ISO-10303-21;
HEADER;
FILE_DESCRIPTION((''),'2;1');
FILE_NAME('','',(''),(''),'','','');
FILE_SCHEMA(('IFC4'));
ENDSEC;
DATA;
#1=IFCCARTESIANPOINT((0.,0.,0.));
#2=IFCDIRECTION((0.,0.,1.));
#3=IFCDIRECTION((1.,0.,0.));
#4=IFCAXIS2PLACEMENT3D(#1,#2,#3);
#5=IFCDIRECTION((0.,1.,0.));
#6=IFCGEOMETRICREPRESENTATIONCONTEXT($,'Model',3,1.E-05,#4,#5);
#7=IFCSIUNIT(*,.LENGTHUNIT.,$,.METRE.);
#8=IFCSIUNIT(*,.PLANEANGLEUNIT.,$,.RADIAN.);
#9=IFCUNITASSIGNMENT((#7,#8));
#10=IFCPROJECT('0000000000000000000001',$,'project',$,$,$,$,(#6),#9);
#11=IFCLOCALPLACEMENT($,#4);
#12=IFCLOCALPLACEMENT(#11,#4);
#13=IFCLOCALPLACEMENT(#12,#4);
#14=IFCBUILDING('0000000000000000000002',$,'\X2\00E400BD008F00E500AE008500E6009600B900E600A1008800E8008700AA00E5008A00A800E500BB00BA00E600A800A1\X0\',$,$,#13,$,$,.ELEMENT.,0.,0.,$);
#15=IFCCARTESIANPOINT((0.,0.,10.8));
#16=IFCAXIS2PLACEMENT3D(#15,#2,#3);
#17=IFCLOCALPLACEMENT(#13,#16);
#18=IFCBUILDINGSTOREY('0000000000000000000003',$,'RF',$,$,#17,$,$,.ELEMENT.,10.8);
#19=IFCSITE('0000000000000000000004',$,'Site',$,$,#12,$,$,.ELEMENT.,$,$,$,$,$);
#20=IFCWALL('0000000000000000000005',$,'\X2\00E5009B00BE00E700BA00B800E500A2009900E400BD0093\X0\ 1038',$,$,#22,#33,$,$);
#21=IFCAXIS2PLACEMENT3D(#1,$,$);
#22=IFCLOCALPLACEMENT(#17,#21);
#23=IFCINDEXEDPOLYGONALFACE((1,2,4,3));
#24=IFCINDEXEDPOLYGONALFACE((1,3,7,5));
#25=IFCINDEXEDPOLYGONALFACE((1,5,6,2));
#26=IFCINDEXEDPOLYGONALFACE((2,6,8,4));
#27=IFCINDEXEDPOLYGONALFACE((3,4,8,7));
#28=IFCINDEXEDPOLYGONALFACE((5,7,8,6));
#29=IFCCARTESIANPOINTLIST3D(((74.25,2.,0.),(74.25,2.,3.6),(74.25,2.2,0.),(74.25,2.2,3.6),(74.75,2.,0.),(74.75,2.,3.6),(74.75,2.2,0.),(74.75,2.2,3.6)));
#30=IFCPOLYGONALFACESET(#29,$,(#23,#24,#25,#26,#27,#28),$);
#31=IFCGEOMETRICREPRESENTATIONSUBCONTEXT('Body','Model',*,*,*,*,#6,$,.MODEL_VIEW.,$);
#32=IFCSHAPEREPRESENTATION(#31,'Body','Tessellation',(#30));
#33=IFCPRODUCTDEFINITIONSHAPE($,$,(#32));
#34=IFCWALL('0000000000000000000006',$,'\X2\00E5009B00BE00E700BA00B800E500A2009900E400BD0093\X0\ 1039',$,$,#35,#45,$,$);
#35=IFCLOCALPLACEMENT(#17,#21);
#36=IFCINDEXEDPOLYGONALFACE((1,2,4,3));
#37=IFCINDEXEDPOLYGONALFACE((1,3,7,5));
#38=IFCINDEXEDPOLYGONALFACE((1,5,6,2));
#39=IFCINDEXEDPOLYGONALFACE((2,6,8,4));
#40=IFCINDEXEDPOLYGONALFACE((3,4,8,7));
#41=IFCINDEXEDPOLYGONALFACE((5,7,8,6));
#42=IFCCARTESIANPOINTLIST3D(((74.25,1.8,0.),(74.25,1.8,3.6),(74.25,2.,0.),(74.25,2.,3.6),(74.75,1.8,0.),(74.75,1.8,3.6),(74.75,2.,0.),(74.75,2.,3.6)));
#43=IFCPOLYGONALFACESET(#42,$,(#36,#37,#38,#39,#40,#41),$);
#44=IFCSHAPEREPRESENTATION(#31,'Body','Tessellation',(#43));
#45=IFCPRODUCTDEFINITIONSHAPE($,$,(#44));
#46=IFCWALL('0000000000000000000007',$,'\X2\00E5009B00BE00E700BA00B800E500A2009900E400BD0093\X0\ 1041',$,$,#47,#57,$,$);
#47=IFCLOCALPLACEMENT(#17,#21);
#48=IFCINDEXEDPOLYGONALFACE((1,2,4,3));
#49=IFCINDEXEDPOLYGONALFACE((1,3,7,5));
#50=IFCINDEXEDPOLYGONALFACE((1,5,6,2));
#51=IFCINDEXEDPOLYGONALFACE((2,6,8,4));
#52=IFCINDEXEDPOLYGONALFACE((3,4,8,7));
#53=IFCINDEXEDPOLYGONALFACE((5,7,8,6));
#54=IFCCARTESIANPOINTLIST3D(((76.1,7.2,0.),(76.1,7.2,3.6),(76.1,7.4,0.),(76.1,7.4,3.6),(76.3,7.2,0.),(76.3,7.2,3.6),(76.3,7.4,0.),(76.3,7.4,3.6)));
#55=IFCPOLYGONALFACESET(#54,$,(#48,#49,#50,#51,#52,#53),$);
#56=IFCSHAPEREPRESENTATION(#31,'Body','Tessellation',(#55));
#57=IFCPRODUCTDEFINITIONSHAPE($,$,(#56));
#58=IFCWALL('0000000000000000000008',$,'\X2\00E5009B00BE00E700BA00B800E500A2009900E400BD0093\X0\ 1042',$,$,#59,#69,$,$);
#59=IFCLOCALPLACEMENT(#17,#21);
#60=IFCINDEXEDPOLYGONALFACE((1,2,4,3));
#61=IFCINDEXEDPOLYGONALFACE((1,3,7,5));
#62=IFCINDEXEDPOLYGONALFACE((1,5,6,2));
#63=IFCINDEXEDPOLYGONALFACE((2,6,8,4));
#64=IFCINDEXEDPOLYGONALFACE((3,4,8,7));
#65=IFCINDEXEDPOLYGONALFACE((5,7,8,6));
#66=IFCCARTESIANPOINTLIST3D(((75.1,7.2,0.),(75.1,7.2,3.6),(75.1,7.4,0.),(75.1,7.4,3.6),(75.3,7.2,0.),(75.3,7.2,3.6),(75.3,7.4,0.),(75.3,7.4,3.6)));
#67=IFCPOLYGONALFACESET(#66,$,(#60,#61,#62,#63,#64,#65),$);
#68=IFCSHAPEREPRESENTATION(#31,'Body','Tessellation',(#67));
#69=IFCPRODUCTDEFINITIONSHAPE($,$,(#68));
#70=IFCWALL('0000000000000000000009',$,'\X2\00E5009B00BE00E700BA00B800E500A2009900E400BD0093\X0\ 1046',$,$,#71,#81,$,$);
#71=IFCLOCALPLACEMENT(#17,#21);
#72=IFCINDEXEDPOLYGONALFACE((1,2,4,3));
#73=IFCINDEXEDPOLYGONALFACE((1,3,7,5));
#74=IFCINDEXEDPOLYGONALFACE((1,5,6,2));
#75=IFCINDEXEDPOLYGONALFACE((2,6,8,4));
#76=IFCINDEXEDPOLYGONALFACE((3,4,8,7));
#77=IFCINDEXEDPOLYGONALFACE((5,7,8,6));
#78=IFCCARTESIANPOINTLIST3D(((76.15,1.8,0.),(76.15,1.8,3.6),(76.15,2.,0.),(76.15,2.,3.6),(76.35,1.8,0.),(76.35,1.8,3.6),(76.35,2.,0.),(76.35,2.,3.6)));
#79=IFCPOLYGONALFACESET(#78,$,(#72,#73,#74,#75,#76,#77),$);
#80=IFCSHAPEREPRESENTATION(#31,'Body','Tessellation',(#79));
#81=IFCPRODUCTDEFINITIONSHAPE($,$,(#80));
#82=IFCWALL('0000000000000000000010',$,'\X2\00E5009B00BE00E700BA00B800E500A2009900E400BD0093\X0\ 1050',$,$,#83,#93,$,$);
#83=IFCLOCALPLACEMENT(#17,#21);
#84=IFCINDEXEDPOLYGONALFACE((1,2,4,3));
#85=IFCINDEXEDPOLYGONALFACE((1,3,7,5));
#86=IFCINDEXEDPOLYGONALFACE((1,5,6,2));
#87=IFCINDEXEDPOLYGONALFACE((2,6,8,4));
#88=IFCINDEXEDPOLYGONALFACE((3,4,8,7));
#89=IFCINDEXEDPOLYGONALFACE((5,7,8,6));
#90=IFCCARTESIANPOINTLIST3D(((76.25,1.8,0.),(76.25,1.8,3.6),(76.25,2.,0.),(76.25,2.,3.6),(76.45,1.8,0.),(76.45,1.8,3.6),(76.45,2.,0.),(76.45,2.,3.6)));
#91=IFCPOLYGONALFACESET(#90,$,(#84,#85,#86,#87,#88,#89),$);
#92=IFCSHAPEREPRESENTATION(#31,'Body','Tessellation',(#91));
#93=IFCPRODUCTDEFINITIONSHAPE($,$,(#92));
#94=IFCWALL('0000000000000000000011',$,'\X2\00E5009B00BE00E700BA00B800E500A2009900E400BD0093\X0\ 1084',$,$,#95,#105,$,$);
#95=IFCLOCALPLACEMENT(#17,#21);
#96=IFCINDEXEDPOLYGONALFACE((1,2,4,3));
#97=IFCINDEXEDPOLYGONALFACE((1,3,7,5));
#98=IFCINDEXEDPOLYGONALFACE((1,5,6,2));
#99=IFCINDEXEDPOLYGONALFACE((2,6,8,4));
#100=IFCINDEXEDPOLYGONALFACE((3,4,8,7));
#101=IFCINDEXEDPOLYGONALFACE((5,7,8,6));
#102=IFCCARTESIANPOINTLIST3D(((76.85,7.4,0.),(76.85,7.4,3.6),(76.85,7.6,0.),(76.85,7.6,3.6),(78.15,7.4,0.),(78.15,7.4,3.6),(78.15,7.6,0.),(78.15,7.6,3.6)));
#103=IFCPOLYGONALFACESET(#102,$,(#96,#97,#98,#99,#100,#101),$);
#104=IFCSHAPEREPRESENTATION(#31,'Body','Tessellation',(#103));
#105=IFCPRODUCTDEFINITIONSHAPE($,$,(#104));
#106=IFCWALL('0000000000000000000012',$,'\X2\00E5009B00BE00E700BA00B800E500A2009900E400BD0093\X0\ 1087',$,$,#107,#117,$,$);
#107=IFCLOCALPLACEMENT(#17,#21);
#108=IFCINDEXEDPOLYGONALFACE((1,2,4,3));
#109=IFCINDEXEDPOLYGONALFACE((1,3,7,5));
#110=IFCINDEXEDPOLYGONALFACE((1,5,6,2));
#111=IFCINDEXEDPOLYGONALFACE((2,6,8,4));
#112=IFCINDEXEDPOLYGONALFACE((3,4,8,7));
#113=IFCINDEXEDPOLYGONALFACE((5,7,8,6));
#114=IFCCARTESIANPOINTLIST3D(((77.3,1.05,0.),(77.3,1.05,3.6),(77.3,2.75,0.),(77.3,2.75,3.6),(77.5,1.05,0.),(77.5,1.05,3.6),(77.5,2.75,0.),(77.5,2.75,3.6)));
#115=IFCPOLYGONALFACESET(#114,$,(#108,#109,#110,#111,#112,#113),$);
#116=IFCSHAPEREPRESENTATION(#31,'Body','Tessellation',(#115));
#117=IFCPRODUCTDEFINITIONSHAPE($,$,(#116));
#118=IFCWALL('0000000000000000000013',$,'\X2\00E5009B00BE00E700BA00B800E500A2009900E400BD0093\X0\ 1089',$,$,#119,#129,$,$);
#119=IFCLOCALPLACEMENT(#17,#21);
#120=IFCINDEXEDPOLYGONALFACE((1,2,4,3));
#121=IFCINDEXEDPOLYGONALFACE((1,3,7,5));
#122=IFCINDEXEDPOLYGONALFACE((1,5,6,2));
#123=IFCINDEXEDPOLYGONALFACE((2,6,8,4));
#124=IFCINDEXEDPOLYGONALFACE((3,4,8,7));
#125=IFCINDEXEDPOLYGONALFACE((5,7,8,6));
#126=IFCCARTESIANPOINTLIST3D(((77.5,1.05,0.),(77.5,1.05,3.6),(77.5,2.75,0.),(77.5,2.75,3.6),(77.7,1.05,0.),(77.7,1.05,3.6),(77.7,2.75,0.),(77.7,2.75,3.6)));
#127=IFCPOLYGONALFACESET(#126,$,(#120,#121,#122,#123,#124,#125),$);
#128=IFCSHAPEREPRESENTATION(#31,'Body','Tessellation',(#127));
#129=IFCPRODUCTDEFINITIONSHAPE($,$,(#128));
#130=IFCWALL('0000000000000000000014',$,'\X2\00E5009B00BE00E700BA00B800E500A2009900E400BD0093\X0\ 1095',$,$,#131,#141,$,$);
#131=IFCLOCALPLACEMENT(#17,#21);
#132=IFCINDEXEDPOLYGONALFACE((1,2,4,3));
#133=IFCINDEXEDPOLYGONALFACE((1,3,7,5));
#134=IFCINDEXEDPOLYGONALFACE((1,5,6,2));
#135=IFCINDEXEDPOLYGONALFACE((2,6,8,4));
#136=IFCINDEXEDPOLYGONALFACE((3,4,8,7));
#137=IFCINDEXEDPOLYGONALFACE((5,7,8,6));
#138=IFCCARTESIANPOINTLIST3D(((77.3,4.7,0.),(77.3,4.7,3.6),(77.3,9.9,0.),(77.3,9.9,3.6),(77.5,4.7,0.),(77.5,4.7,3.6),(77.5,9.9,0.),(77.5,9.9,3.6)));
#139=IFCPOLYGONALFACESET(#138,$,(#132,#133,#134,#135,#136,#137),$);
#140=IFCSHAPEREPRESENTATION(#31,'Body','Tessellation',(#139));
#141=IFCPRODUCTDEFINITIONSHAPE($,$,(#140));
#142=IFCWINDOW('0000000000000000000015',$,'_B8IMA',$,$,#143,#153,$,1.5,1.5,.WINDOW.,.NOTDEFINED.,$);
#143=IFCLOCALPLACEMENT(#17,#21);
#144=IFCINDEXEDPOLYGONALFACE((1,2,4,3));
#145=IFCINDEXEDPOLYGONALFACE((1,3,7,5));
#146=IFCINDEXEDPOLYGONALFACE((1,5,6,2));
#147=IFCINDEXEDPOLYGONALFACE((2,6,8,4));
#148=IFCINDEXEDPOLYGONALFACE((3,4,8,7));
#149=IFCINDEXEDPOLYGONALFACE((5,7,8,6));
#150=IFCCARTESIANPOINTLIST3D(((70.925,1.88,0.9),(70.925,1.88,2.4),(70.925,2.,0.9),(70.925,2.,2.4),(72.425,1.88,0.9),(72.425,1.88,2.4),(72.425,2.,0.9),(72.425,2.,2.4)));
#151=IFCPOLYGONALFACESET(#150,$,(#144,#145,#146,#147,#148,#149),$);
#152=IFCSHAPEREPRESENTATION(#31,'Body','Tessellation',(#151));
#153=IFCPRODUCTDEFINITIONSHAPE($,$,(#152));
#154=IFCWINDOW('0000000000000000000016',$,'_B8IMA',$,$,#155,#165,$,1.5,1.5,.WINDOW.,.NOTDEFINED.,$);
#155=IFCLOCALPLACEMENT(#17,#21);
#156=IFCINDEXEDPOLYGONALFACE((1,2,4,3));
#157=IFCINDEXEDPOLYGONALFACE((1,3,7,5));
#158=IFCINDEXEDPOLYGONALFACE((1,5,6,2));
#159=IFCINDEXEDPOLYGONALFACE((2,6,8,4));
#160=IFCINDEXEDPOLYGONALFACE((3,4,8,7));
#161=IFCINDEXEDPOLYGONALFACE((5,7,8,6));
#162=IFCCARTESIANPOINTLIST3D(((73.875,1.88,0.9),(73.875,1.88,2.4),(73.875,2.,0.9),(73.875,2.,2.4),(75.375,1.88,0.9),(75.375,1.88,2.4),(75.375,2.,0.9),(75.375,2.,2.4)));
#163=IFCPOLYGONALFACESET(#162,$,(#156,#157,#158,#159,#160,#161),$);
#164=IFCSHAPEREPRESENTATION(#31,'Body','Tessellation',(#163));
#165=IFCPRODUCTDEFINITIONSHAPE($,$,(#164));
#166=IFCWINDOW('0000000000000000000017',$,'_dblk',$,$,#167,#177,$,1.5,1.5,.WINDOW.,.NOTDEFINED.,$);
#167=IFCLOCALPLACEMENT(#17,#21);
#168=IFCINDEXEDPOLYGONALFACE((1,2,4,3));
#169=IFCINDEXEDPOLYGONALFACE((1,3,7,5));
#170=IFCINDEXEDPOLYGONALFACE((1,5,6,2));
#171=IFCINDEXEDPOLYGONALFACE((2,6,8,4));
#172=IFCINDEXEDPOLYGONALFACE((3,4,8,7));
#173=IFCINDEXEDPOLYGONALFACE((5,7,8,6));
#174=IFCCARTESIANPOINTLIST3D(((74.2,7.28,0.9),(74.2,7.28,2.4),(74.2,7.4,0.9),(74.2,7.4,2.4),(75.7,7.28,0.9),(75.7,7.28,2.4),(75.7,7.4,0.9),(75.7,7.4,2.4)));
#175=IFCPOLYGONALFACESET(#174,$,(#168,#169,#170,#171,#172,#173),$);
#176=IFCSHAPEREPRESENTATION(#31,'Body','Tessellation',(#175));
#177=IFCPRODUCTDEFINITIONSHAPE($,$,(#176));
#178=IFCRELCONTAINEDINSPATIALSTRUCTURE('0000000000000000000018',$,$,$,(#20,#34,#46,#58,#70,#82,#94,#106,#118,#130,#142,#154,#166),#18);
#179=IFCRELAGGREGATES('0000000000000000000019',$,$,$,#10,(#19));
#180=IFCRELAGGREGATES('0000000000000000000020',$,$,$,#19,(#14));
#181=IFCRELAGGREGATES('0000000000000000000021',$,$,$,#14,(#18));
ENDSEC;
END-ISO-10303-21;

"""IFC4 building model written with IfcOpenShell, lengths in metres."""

from ifc_helpers import new_model, si_unit, direction, frame, frame_2d, origin_with_axes, place, context, subcontext, project, spatial, rectangle, extrude, element, save


model = new_model("IFC4")

# Units and contexts
model_context = context("Model", 3, precision=1e-05, world=origin_with_axes(), true_north=direction((0.0, 1.0, 0.0)))
body_context = subcontext(model_context, "Body", "Model", "MODEL_VIEW")
ifc_project = project(units=[si_unit("LENGTHUNIT", "METRE"), si_unit("PLANEANGLEUNIT", "RADIAN")], contexts=[model_context])

# Site, building, storey
placement = place(None, origin_with_axes())
site_placement = place(placement, origin_with_axes())
site = spatial("IfcSite", under=ifc_project, at=site_placement, Name="Site", CompositionType="ELEMENT")
building_placement = place(site_placement, origin_with_axes())
building = spatial("IfcBuilding", under=site, at=building_placement, Name="ä½\u008få®\u0085æ\u0096¹æ¡\u0088è\u0087ªå\u008a¨å»ºæ¨¡", CompositionType="ELEMENT", ElevationOfRefHeight=0.0, ElevationOfTerrain=0.0)
storey_placement = place(building_placement, frame((0.0, 0.0, 10.8), z_axis=(0.0, 0.0, 1.0), x_axis=(1.0, 0.0, 0.0)))
storey = spatial("IfcBuildingStorey", under=building, at=storey_placement, Name="RF", CompositionType="ELEMENT", Elevation=10.8)

# Walls
for number, where, z_axis, x_axis, name in (
    (1, (74.5, 2.1, 0.0), (0.0, 0.0, 1.0), (-1.0, 0.0, 0.0), "å\u009b¾çº¸å¢\u0099ä½\u0093 1038"),
    (2, (74.5, 1.9, 0.0), (0.0, 0.0, 1.0), (-1.0, 0.0, 0.0), "å\u009b¾çº¸å¢\u0099ä½\u0093 1039"),
):
    element("IfcWall", number, at=place(storey_placement, frame(where, z_axis=z_axis, x_axis=x_axis)), inside=storey, Name=name, context=body_context, shape_type="SweptSolid", body=[
        extrude(rectangle(XDim=0.5, YDim=0.2, at=frame_2d((0.0, 0.0), x_axis=(1.0, 0.0, 0.0))), frame((0.0, 0.0, 0.0), z_axis=(0.0, 0.0, 1.0)), (0.0, 0.0, 1.0), 3.6),
    ])
for number, where, z_axis, x_axis, name in (
    (3, (76.2, 7.3, 0.0), (0.0, 0.0, 1.0), (0.0, 1.0, 0.0), "å\u009b¾çº¸å¢\u0099ä½\u0093 1041"),
    (4, (75.2, 7.3, 0.0), (0.0, 0.0, 1.0), (0.0, 1.0, 0.0), "å\u009b¾çº¸å¢\u0099ä½\u0093 1042"),
    (5, (76.25, 1.9, 0.0), (0.0, 0.0, 1.0), (0.0, 1.0, 0.0), "å\u009b¾çº¸å¢\u0099ä½\u0093 1046"),
    (6, (76.35, 1.9, 0.0), (0.0, 0.0, 1.0), (0.0, -1.0, 0.0), "å\u009b¾çº¸å¢\u0099ä½\u0093 1050"),
):
    element("IfcWall", number, at=place(storey_placement, frame(where, z_axis=z_axis, x_axis=x_axis)), inside=storey, Name=name, context=body_context, shape_type="SweptSolid", body=[
        extrude(rectangle(XDim=0.2, YDim=0.2, at=frame_2d((0.0, 0.0), x_axis=(1.0, 0.0, 0.0))), frame((0.0, 0.0, 0.0), z_axis=(0.0, 0.0, 1.0)), (0.0, 0.0, 1.0), 3.6),
    ])
wall_1_placement = place(storey_placement, frame((77.5, 7.5, 0.0), z_axis=(0.0, 0.0, 1.0), x_axis=(1.0, 0.0, 0.0)))
element("IfcWall", 7, at=wall_1_placement, inside=storey, Name="å\u009b¾çº¸å¢\u0099ä½\u0093 1084", context=body_context, shape_type="SweptSolid", body=[
    extrude(rectangle(XDim=1.3, YDim=0.2, at=frame_2d((0.0, 0.0), x_axis=(1.0, 0.0, 0.0))), frame((0.0, 0.0, 0.0), z_axis=(0.0, 0.0, 1.0)), (0.0, 0.0, 1.0), 3.6),
])
for number, where, z_axis, x_axis, name in (
    (8, (77.4, 1.9, 0.0), (0.0, 0.0, 1.0), (0.0, -1.0, 0.0), "å\u009b¾çº¸å¢\u0099ä½\u0093 1087"),
    (9, (77.6, 1.9, 0.0), (0.0, 0.0, 1.0), (0.0, -1.0, 0.0), "å\u009b¾çº¸å¢\u0099ä½\u0093 1089"),
):
    element("IfcWall", number, at=place(storey_placement, frame(where, z_axis=z_axis, x_axis=x_axis)), inside=storey, Name=name, context=body_context, shape_type="SweptSolid", body=[
        extrude(rectangle(XDim=1.7, YDim=0.2, at=frame_2d((0.0, 0.0), x_axis=(1.0, 0.0, 0.0))), frame((0.0, 0.0, 0.0), z_axis=(0.0, 0.0, 1.0)), (0.0, 0.0, 1.0), 3.6),
    ])
wall_2_placement = place(storey_placement, frame((77.4, 7.3, 0.0), z_axis=(0.0, 0.0, 1.0), x_axis=(0.0, -1.0, 0.0)))
element("IfcWall", 10, at=wall_2_placement, inside=storey, Name="å\u009b¾çº¸å¢\u0099ä½\u0093 1095", context=body_context, shape_type="SweptSolid", body=[
    extrude(rectangle(XDim=5.2, YDim=0.2, at=frame_2d((0.0, 0.0), x_axis=(1.0, 0.0, 0.0))), frame((0.0, 0.0, 0.0), z_axis=(0.0, 0.0, 1.0)), (0.0, 0.0, 1.0), 3.6),
])

# Windows
for number, where, z_axis, x_axis, name in (
    (11, (71.675, 1.94, 0.9), (0.0, 0.0, 1.0), (1.0, 0.0, 0.0), "_B8IMA"),
    (12, (74.625, 1.94, 0.9), (0.0, 0.0, 1.0), (1.0, 0.0, 0.0), "_B8IMA"),
    (13, (74.95, 7.34, 0.9), (0.0, 0.0, 1.0), (1.0, 0.0, 0.0), "_dblk"),
):
    element("IfcWindow", number, at=place(storey_placement, frame(where, z_axis=z_axis, x_axis=x_axis)), inside=storey, Name=name, OverallHeight=1.5, OverallWidth=1.5, PartitioningType="NOTDEFINED", PredefinedType="WINDOW", context=body_context, shape_type="SweptSolid", body=[
        extrude(rectangle(XDim=1.5, YDim=0.12, at=frame_2d((0.0, 0.0), x_axis=(1.0, 0.0, 0.0))), frame((0.0, 0.0, 0.0), z_axis=(0.0, 0.0, 1.0)), (0.0, 0.0, 1.0), 1.5),
    ])

save(model, "model.ifc")
